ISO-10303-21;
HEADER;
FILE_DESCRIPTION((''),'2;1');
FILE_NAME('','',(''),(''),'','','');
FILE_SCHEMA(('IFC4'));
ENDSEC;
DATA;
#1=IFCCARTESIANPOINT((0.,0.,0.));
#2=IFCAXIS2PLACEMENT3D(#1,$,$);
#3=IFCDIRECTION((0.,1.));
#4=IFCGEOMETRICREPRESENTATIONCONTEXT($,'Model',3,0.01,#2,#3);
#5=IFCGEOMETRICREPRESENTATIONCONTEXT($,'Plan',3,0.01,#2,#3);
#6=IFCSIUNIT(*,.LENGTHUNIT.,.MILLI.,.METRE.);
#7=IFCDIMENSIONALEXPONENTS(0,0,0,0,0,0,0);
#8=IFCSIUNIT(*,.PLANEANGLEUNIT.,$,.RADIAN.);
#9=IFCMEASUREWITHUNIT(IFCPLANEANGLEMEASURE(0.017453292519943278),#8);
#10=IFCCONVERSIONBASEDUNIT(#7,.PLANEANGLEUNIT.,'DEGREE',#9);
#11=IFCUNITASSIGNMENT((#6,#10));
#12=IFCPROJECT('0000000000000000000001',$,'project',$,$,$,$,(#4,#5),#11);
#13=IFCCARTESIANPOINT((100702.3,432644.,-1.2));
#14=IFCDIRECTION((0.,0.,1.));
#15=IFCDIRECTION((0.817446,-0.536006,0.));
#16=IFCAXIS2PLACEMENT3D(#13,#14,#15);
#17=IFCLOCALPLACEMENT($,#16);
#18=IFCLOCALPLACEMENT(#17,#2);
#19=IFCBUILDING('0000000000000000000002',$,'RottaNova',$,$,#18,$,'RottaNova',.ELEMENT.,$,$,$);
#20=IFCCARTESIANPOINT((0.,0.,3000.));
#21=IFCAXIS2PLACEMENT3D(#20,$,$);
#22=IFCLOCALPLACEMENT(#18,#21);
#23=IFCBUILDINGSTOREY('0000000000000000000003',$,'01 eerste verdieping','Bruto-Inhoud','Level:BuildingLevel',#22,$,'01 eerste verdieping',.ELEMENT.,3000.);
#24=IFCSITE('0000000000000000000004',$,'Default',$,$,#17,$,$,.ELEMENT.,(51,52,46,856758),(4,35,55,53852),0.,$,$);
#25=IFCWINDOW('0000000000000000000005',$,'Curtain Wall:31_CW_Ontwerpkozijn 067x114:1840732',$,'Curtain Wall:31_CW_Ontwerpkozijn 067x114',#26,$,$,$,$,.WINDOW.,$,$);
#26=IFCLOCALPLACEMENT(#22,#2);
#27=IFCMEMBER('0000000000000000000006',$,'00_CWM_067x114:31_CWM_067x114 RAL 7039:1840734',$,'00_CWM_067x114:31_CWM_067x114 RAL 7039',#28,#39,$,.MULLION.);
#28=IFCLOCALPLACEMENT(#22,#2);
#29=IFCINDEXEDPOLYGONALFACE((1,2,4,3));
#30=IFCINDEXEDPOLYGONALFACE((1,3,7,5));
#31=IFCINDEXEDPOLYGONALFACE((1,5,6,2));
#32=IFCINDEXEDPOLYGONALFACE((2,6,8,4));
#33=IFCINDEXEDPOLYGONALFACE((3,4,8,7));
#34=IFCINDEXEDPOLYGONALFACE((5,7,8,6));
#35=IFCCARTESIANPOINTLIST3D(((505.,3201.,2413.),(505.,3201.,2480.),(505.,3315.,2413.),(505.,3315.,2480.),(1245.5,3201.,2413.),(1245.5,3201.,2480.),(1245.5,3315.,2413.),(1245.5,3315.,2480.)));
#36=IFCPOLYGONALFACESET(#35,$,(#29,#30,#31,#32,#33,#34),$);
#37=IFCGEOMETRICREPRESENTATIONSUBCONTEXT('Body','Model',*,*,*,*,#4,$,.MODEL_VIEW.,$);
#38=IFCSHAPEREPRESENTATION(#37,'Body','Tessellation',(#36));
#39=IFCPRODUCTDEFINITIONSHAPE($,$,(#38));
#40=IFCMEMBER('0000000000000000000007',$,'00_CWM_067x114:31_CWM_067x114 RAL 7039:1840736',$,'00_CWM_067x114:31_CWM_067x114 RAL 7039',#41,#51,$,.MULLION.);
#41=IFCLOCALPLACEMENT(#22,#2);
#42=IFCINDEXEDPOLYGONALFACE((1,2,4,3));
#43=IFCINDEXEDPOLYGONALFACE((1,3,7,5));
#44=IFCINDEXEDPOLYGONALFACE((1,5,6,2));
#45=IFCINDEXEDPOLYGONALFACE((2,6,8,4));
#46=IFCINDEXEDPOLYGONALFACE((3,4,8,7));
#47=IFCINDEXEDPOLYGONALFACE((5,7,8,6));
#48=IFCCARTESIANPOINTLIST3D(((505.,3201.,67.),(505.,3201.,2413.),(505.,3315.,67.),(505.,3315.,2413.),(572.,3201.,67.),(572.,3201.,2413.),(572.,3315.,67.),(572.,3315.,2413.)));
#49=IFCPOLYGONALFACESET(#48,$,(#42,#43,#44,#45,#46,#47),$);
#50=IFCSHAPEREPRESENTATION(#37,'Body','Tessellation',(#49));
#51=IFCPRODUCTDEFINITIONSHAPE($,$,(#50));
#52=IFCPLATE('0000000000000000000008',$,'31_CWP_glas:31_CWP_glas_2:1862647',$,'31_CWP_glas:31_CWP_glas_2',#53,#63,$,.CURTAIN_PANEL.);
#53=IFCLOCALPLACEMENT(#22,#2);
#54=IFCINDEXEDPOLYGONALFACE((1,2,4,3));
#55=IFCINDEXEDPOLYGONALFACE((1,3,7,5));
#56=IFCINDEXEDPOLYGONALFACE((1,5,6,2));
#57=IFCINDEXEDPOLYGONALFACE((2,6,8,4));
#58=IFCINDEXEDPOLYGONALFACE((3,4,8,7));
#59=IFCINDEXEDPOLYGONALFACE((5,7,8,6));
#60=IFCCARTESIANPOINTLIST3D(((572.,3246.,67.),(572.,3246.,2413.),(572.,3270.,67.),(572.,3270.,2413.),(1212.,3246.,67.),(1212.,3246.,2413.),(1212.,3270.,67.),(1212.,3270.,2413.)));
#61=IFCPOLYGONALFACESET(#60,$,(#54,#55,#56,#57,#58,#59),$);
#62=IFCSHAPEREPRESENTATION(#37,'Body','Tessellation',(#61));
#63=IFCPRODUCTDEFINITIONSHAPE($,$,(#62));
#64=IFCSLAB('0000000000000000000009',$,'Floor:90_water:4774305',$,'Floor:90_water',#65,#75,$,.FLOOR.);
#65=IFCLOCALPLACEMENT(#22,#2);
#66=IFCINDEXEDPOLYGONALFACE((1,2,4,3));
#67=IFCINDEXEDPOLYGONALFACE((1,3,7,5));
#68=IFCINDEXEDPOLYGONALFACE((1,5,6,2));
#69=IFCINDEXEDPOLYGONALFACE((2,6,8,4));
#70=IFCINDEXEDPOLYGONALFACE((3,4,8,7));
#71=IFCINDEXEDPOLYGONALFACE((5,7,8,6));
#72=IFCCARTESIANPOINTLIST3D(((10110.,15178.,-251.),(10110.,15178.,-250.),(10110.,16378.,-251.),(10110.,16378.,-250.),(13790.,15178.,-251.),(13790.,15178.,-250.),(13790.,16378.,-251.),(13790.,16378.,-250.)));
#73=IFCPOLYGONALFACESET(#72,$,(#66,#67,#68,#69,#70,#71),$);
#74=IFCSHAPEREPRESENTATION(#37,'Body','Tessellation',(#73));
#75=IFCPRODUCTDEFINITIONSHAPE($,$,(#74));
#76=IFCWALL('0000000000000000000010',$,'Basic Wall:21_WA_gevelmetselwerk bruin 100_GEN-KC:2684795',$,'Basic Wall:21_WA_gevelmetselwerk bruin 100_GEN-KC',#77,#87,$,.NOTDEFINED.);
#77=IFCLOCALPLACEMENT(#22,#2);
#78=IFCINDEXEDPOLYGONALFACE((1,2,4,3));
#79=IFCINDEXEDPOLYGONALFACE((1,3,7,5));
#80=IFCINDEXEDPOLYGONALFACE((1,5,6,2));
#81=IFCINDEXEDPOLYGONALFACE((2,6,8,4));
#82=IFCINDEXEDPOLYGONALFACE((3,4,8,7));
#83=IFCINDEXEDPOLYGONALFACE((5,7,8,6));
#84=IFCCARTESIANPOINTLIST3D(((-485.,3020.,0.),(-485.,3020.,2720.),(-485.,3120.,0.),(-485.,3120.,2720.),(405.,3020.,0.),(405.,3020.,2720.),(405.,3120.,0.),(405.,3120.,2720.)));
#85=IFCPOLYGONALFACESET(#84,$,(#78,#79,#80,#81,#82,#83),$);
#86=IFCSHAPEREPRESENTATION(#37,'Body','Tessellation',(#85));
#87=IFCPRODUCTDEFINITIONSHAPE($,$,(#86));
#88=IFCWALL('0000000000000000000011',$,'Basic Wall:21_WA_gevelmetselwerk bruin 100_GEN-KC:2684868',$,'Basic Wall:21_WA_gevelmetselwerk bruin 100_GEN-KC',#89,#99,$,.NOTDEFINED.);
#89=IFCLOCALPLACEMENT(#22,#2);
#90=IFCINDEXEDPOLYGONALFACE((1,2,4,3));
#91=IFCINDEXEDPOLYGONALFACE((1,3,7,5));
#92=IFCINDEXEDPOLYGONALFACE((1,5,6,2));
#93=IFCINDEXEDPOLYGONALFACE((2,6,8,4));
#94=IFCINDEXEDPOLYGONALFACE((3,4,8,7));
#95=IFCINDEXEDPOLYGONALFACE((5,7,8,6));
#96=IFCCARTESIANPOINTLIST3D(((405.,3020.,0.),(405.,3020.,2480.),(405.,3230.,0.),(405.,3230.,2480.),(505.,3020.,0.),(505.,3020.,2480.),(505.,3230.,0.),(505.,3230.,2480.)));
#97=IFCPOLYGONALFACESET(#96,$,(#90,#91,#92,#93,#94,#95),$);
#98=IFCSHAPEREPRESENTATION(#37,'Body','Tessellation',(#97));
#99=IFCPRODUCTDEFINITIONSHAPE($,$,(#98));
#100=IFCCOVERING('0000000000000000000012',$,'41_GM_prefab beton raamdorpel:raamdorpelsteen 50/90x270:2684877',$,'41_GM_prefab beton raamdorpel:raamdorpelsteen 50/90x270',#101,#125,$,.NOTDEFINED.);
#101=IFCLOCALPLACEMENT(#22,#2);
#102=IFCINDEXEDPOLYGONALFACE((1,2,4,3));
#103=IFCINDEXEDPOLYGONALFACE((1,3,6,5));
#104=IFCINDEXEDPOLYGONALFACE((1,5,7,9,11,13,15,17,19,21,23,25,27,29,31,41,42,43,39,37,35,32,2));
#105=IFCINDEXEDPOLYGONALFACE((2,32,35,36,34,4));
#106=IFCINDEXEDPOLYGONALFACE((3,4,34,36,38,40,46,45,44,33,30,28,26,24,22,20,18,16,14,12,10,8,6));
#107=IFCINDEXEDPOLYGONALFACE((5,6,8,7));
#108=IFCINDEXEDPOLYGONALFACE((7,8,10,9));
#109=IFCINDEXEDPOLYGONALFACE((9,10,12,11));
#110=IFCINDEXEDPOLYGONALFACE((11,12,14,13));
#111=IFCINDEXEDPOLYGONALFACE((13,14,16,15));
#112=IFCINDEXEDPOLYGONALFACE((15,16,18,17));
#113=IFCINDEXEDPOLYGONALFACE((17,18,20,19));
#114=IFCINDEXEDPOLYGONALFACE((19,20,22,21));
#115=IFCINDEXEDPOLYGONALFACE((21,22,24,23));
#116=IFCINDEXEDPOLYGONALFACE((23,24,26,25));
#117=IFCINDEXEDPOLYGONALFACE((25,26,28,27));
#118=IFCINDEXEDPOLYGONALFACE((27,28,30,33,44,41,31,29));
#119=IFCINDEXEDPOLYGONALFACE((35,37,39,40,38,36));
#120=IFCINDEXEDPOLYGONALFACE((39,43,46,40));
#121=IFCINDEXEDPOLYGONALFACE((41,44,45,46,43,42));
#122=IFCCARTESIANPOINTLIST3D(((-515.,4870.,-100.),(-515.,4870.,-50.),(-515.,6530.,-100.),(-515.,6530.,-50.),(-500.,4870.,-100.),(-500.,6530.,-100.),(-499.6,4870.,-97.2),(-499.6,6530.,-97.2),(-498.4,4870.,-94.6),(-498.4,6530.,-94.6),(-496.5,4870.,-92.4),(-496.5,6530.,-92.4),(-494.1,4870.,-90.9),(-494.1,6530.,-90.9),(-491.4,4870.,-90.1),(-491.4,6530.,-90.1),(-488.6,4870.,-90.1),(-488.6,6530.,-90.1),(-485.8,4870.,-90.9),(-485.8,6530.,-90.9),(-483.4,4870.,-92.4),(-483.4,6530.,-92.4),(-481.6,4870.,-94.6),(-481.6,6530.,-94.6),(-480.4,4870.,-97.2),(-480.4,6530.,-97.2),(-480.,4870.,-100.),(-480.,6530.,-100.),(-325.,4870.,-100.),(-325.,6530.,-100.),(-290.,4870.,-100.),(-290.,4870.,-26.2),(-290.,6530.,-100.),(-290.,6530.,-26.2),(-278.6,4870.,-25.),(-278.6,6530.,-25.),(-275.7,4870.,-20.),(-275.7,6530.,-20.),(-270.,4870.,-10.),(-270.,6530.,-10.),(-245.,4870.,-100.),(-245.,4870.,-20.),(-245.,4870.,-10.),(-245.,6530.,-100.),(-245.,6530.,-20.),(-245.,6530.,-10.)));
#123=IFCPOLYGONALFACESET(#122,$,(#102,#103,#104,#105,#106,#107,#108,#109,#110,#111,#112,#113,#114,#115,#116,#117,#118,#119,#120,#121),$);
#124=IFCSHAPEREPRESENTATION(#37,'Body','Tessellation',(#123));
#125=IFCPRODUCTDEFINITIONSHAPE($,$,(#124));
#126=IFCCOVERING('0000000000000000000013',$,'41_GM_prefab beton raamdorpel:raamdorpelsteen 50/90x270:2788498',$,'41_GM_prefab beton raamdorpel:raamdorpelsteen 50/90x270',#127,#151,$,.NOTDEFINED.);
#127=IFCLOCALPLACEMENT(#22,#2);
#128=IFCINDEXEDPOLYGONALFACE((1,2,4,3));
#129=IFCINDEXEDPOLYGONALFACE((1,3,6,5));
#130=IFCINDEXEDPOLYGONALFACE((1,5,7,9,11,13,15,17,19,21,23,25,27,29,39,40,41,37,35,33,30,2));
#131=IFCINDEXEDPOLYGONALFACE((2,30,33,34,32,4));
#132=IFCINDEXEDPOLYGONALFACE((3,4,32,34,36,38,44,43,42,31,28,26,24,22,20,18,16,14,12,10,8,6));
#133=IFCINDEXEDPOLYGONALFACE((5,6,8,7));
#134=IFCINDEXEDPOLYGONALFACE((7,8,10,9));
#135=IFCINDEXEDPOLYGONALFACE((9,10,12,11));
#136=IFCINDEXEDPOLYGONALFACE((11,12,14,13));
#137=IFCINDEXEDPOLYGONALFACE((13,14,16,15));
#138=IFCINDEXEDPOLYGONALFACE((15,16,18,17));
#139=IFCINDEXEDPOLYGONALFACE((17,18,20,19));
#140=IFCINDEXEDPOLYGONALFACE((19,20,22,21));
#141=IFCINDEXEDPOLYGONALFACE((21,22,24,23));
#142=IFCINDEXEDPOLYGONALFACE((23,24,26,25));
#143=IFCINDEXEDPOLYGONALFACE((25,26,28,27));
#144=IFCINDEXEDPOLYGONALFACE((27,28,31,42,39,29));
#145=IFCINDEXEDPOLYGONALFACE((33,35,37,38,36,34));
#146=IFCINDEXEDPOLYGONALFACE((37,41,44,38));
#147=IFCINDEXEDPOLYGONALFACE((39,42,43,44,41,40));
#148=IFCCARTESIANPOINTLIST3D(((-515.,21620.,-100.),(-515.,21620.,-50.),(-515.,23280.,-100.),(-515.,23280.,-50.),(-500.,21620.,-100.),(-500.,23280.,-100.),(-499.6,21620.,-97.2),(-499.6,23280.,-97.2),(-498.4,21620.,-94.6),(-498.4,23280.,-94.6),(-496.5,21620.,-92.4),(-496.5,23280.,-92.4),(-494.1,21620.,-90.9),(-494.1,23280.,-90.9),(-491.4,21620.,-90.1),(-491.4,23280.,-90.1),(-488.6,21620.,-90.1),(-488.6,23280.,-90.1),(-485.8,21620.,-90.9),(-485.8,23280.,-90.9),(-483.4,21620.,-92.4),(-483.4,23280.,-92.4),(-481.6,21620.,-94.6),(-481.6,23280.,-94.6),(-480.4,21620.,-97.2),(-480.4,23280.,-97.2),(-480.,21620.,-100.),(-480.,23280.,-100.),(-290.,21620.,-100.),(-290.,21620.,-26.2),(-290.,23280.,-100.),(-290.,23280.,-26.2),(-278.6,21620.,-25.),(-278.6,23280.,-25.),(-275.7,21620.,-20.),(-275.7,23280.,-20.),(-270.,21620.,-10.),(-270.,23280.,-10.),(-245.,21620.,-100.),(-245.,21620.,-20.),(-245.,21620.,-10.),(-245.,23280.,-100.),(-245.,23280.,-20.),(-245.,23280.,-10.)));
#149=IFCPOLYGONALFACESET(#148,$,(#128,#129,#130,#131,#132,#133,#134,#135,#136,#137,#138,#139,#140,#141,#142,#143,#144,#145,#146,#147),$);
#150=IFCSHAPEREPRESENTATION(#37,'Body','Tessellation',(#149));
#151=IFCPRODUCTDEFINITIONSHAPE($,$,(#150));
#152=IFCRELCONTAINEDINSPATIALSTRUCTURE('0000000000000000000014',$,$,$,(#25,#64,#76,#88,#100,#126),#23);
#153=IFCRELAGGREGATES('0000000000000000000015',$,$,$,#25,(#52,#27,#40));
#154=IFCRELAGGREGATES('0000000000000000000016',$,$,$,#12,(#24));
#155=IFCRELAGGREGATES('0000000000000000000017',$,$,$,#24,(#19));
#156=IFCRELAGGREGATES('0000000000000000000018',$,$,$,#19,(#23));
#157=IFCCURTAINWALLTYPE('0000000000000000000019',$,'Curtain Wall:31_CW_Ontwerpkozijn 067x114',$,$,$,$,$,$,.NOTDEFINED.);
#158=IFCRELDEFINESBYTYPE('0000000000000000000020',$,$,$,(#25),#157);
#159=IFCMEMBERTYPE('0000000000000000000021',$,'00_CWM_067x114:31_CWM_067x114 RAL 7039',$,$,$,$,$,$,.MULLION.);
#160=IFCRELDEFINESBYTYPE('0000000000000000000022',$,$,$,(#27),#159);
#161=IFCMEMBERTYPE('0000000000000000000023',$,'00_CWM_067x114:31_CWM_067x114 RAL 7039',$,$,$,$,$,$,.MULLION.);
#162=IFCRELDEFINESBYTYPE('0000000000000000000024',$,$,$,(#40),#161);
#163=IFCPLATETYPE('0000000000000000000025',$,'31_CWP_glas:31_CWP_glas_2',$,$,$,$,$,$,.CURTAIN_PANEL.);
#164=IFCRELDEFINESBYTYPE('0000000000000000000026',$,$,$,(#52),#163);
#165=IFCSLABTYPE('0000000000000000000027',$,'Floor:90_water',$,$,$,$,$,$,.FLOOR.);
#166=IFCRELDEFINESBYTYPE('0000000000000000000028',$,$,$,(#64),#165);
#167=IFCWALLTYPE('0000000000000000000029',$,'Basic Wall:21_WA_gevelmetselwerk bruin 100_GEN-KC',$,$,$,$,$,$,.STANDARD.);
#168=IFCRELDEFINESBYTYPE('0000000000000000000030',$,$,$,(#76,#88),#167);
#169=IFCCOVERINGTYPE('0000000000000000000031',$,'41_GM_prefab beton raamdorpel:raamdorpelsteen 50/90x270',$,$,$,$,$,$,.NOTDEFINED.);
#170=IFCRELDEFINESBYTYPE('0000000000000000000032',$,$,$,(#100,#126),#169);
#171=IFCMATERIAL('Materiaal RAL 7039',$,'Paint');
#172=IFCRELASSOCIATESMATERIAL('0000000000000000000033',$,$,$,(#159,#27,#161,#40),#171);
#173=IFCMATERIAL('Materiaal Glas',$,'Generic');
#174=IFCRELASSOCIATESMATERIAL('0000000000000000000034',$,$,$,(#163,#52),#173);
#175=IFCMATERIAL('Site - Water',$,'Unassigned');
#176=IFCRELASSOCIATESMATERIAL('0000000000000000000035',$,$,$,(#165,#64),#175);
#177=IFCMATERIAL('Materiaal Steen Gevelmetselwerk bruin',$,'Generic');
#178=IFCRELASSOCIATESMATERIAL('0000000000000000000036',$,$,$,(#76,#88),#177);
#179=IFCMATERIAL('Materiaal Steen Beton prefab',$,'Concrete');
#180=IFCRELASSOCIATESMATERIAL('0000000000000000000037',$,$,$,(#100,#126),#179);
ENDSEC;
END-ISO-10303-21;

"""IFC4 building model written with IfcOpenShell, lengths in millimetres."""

from ifc_helpers import new_model, entity, si_unit, converted_unit, direction, frame, origin, place, context, subcontext, project, spatial, line, arc, indexed_curve, outline, extrude, source, transform, mapped, material, type_object, type_shapes, element, aggregate, save


model = new_model("IFC4")

# Units and contexts
model_context = context("Model", 3, precision=0.01, world=origin(), true_north=direction((0.0, 1.0)))
plan_context = context("Plan", 3, precision=0.01, world=origin(), true_north=direction((0.0, 1.0)))
body_context = subcontext(model_context, "Body", "Model", "MODEL_VIEW")
ifc_project = project(units=[si_unit("LENGTHUNIT", "METRE", prefix="MILLI"), converted_unit("PLANEANGLEUNIT", "DEGREE", entity("IfcPlaneAngleMeasure", 0.017453292519943278), si_unit("PLANEANGLEUNIT", "RADIAN"), dimensions=[0, 0, 0, 0, 0, 0, 0])], contexts=[model_context, plan_context])

# Site, building, storey
site_placement = place(None, frame((100702.3, 432644.0, -1.2), z_axis=(0.0, 0.0, 1.0), x_axis=(0.817446, -0.536006, 0.0)))
site = spatial("IfcSite", under=ifc_project, at=site_placement, Name="Default", CompositionType="ELEMENT", RefLatitude=(51, 52, 46, 856758), RefLongitude=(4, 35, 55, 53852), RefElevation=0.0)
building_placement = place(site_placement, origin())
building = spatial("IfcBuilding", under=site, at=building_placement, Name="RottaNova", LongName="RottaNova", CompositionType="ELEMENT")
storey_placement = place(building_placement, frame((0.0, 0.0, 3000.0)))
storey = spatial("IfcBuildingStorey", under=building, at=storey_placement, Name="01 eerste verdieping", Description="Bruto-Inhoud", ObjectType="Level:BuildingLevel", LongName="01 eerste verdieping", CompositionType="ELEMENT", Elevation=3000.0)

# Window, members
curtain_wall_type = type_object("IfcCurtainWallType", Name="Curtain Wall:31_CW_Ontwerpkozijn 067x114", PredefinedType="NOTDEFINED")
window_placement = place(storey_placement, frame((0.0, 0.0, -3000.0)))
window = element("IfcWindow", 1, at=window_placement, inside=storey, type_object=curtain_wall_type, Name="Curtain Wall:31_CW_Ontwerpkozijn 067x114:1840732", ObjectType="Curtain Wall:31_CW_Ontwerpkozijn 067x114", PredefinedType="WINDOW")
ifc_material_1 = material(Name="Materiaal RAL 7039", Category="Paint")
member_type_1 = type_object("IfcMemberType", Name="00_CWM_067x114:31_CWM_067x114 RAL 7039", PredefinedType="MULLION", material=ifc_material_1)
shared_shape_1 = source(origin(), body_context, "Body", "SweptSolid", [
    extrude(outline(indexed_curve([(-33.5, -57.0), (33.5, -57.0), (33.5, 57.0), (-33.5, 57.0), (-33.5, -57.0)], self_intersect=False)), frame((-33.5, -57.0, -740.5), z_axis=(0.0, 0.0, 1.0), x_axis=(-1.0, 0.0, 0.0)), (0.0, 0.0, 1.0), 740.5),
])
type_shapes(member_type_1, [shared_shape_1])
member_1_placement = place(window_placement, frame((505.0, 3315.0, 5480.0), z_axis=(-1.0, 0.0, 0.0), x_axis=(0.0, 0.0, 1.0)))
member_1 = element("IfcMember", 2, at=member_1_placement, type_object=member_type_1, material=ifc_material_1, Name="00_CWM_067x114:31_CWM_067x114 RAL 7039:1840734", ObjectType="00_CWM_067x114:31_CWM_067x114 RAL 7039", PredefinedType="MULLION", context=body_context, shape_type="MappedRepresentation", body=[
    mapped(shared_shape_1, transform((0.0, 0.0, 0.0), scale=1.0)),
])
member_type_2 = type_object("IfcMemberType", Name="00_CWM_067x114:31_CWM_067x114 RAL 7039", PredefinedType="MULLION", material=ifc_material_1)
shared_shape_2 = source(origin(), body_context, "Body", "SweptSolid", [
    extrude(outline(indexed_curve([(-33.5, -57.0), (33.5, -57.0), (33.5, 57.0), (-33.5, 57.0), (-33.5, -57.0)], self_intersect=False)), frame((-33.5, -57.0, -2346.0), z_axis=(0.0, 0.0, 1.0), x_axis=(-1.0, 0.0, 0.0)), (0.0, 0.0, 1.0), 2346.0),
])
type_shapes(member_type_2, [shared_shape_2])
member_2_placement = place(window_placement, frame((505.0, 3315.0, 3067.0), z_axis=(0.0, 0.0, -1.0), x_axis=(-1.0, 0.0, 0.0)))
member_2 = element("IfcMember", 3, at=member_2_placement, type_object=member_type_2, material=ifc_material_1, Name="00_CWM_067x114:31_CWM_067x114 RAL 7039:1840736", ObjectType="00_CWM_067x114:31_CWM_067x114 RAL 7039", PredefinedType="MULLION", context=body_context, shape_type="MappedRepresentation", body=[
    mapped(shared_shape_2, transform((0.0, 0.0, 0.0), scale=1.0)),
])

# Plate
ifc_material_2 = material(Name="Materiaal Glas", Category="Generic")
plate_type = type_object("IfcPlateType", Name="31_CWP_glas:31_CWP_glas_2", PredefinedType="CURTAIN_PANEL", material=ifc_material_2)
shared_shape_3 = source(origin(), body_context, "Body", "SweptSolid", [
    extrude(outline(indexed_curve([(-12.0, -320.0), (12.0, -320.0), (12.0, 320.0), (-12.0, 320.0), (-12.0, -320.0)], self_intersect=False)), frame((0.0, 57.0, 0.0), z_axis=(0.0, 0.0, 1.0), x_axis=(0.0, 1.0, 0.0)), (0.0, 0.0, 1.0), 2346.0),
])
type_shapes(plate_type, [shared_shape_3])
plate_placement = place(window_placement, frame((892.0, 3315.0, 3067.0), z_axis=(0.0, 0.0, 1.0), x_axis=(-1.0, 0.0, 0.0)))
plate = element("IfcPlate", 4, at=plate_placement, type_object=plate_type, material=ifc_material_2, Name="31_CWP_glas:31_CWP_glas_2:1862647", ObjectType="31_CWP_glas:31_CWP_glas_2", PredefinedType="CURTAIN_PANEL", context=body_context, shape_type="MappedRepresentation", body=[
    mapped(shared_shape_3, transform((0.0, 0.0, 0.0), scale=1.0)),
])
aggregate(window, [plate, member_1, member_2])

# Slab
ifc_material_3 = material(Name="Site - Water", Category="Unassigned")
slab_type_1 = type_object("IfcSlabType", Name="Floor:90_water", PredefinedType="FLOOR", material=ifc_material_3)
slab_1_placement = place(storey_placement, origin())
element("IfcSlab", 5, at=slab_1_placement, inside=storey, type_object=slab_type_1, material=ifc_material_3, Name="Floor:90_water:4774305", ObjectType="Floor:90_water", PredefinedType="FLOOR", context=body_context, shape_type="SweptSolid", body=[
    extrude(outline(indexed_curve([(-600.0, -1840.0), (600.0, -1840.0), (600.0, 1840.0), (-600.0, 1840.0), (-600.0, -1840.0)], self_intersect=False)), frame((11950.0, 15778.0, -250.0), z_axis=(0.0, 0.0, -1.0), x_axis=(0.0, 1.0, 0.0)), (0.0, 0.0, 1.0), 1.0),
])

# Walls
ifc_material_4 = material(Name="Materiaal Steen Gevelmetselwerk bruin", Category="Generic")
wall_type = type_object("IfcWallType", Name="Basic Wall:21_WA_gevelmetselwerk bruin 100_GEN-KC", PredefinedType="STANDARD")
wall_1_placement = place(storey_placement, frame((405.0, 3070.0, 0.0), z_axis=(0.0, 0.0, 1.0), x_axis=(-1.0, 0.0, 0.0)))
element("IfcWall", 6, at=wall_1_placement, inside=storey, type_object=wall_type, material=ifc_material_4, Name="Basic Wall:21_WA_gevelmetselwerk bruin 100_GEN-KC:2684795", ObjectType="Basic Wall:21_WA_gevelmetselwerk bruin 100_GEN-KC", PredefinedType="NOTDEFINED", context=body_context, shape_type="SweptSolid", body=[
    extrude(outline(indexed_curve([(890.0, 50.0), (0.0, 50.0), (0.0, -50.0), (890.0, -50.0), (890.0, 50.0)], self_intersect=False)), origin(), (0.0, 0.0, 1.0), 2720.0),
])
wall_2_placement = place(storey_placement, frame((455.0, 3230.0, 0.0), z_axis=(0.0, 0.0, 1.0), x_axis=(0.0, -1.0, 0.0)))
element("IfcWall", 7, at=wall_2_placement, inside=storey, type_object=wall_type, material=ifc_material_4, Name="Basic Wall:21_WA_gevelmetselwerk bruin 100_GEN-KC:2684868", ObjectType="Basic Wall:21_WA_gevelmetselwerk bruin 100_GEN-KC", PredefinedType="NOTDEFINED", context=body_context, shape_type="SweptSolid", body=[
    extrude(outline(indexed_curve([(210.0, 50.0), (0.0, 50.0), (0.0, -50.0), (210.0, -50.0), (210.0, 50.0)], self_intersect=False)), origin(), (0.0, 0.0, 1.0), 2480.0),
])

# Coverings
ifc_material_5 = material(Name="Materiaal Steen Beton prefab", Category="Concrete")
covering_type_1 = type_object("IfcCoveringType", Name="41_GM_prefab beton raamdorpel:raamdorpelsteen 50/90x270", PredefinedType="NOTDEFINED")
covering_1_placement = place(storey_placement, origin())
element("IfcCovering", 8, at=covering_1_placement, inside=storey, type_object=covering_type_1, material=ifc_material_5, Name="41_GM_prefab beton raamdorpel:raamdorpelsteen 50/90x270:2684877", ObjectType="41_GM_prefab beton raamdorpel:raamdorpelsteen 50/90x270", PredefinedType="NOTDEFINED", context=body_context, shape_type="SweptSolid", body=[
    extrude(outline(indexed_curve([(74.2, -48.6), (99.2, -48.6), (99.2, -38.6), (99.2, 41.4), (54.2, 41.4), (19.2, 41.4), (-135.8, 41.4), (-145.8, 31.4), (-155.8, 41.4), (-170.8, 41.4), (-170.8, -8.6), (54.2, -32.4), (65.5, -33.6), (68.4, -38.6)], segments=[line(1, 2, 3, 4, 5, 6, 7), arc(7, 8, 9), line(9, 10, 11, 12, 13, 14, 1)], self_intersect=False)), frame((-344.2, 4870.0, -58.6), z_axis=(0.0, 1.0, 0.0), x_axis=(1.0, 0.0, 0.0)), (0.0, 0.0, 1.0), 1660.0),
])
covering_2_placement = place(storey_placement, origin())
element("IfcCovering", 9, at=covering_2_placement, inside=storey, type_object=covering_type_1, material=ifc_material_5, Name="41_GM_prefab beton raamdorpel:raamdorpelsteen 50/90x270:2788498", ObjectType="41_GM_prefab beton raamdorpel:raamdorpelsteen 50/90x270", PredefinedType="NOTDEFINED", context=body_context, shape_type="SweptSolid", body=[
    extrude(outline(indexed_curve([(75.8, -45.1), (100.8, -45.1), (100.8, -35.1), (100.8, 44.9), (55.8, 44.9), (-134.2, 44.9), (-144.2, 34.9), (-154.2, 44.9), (-169.2, 44.9), (-169.2, -5.1), (55.8, -28.9), (67.1, -30.1), (70.0, -35.1)], segments=[line(1, 2, 3, 4, 5, 6), arc(6, 7, 8), line(8, 9, 10, 11, 12, 13, 1)], self_intersect=False)), frame((-345.8, 21620.0, -55.1), z_axis=(0.0, 1.0, 0.0), x_axis=(1.0, 0.0, 0.0)), (0.0, 0.0, 1.0), 1660.0),
])

save(model, "model.ifc")
